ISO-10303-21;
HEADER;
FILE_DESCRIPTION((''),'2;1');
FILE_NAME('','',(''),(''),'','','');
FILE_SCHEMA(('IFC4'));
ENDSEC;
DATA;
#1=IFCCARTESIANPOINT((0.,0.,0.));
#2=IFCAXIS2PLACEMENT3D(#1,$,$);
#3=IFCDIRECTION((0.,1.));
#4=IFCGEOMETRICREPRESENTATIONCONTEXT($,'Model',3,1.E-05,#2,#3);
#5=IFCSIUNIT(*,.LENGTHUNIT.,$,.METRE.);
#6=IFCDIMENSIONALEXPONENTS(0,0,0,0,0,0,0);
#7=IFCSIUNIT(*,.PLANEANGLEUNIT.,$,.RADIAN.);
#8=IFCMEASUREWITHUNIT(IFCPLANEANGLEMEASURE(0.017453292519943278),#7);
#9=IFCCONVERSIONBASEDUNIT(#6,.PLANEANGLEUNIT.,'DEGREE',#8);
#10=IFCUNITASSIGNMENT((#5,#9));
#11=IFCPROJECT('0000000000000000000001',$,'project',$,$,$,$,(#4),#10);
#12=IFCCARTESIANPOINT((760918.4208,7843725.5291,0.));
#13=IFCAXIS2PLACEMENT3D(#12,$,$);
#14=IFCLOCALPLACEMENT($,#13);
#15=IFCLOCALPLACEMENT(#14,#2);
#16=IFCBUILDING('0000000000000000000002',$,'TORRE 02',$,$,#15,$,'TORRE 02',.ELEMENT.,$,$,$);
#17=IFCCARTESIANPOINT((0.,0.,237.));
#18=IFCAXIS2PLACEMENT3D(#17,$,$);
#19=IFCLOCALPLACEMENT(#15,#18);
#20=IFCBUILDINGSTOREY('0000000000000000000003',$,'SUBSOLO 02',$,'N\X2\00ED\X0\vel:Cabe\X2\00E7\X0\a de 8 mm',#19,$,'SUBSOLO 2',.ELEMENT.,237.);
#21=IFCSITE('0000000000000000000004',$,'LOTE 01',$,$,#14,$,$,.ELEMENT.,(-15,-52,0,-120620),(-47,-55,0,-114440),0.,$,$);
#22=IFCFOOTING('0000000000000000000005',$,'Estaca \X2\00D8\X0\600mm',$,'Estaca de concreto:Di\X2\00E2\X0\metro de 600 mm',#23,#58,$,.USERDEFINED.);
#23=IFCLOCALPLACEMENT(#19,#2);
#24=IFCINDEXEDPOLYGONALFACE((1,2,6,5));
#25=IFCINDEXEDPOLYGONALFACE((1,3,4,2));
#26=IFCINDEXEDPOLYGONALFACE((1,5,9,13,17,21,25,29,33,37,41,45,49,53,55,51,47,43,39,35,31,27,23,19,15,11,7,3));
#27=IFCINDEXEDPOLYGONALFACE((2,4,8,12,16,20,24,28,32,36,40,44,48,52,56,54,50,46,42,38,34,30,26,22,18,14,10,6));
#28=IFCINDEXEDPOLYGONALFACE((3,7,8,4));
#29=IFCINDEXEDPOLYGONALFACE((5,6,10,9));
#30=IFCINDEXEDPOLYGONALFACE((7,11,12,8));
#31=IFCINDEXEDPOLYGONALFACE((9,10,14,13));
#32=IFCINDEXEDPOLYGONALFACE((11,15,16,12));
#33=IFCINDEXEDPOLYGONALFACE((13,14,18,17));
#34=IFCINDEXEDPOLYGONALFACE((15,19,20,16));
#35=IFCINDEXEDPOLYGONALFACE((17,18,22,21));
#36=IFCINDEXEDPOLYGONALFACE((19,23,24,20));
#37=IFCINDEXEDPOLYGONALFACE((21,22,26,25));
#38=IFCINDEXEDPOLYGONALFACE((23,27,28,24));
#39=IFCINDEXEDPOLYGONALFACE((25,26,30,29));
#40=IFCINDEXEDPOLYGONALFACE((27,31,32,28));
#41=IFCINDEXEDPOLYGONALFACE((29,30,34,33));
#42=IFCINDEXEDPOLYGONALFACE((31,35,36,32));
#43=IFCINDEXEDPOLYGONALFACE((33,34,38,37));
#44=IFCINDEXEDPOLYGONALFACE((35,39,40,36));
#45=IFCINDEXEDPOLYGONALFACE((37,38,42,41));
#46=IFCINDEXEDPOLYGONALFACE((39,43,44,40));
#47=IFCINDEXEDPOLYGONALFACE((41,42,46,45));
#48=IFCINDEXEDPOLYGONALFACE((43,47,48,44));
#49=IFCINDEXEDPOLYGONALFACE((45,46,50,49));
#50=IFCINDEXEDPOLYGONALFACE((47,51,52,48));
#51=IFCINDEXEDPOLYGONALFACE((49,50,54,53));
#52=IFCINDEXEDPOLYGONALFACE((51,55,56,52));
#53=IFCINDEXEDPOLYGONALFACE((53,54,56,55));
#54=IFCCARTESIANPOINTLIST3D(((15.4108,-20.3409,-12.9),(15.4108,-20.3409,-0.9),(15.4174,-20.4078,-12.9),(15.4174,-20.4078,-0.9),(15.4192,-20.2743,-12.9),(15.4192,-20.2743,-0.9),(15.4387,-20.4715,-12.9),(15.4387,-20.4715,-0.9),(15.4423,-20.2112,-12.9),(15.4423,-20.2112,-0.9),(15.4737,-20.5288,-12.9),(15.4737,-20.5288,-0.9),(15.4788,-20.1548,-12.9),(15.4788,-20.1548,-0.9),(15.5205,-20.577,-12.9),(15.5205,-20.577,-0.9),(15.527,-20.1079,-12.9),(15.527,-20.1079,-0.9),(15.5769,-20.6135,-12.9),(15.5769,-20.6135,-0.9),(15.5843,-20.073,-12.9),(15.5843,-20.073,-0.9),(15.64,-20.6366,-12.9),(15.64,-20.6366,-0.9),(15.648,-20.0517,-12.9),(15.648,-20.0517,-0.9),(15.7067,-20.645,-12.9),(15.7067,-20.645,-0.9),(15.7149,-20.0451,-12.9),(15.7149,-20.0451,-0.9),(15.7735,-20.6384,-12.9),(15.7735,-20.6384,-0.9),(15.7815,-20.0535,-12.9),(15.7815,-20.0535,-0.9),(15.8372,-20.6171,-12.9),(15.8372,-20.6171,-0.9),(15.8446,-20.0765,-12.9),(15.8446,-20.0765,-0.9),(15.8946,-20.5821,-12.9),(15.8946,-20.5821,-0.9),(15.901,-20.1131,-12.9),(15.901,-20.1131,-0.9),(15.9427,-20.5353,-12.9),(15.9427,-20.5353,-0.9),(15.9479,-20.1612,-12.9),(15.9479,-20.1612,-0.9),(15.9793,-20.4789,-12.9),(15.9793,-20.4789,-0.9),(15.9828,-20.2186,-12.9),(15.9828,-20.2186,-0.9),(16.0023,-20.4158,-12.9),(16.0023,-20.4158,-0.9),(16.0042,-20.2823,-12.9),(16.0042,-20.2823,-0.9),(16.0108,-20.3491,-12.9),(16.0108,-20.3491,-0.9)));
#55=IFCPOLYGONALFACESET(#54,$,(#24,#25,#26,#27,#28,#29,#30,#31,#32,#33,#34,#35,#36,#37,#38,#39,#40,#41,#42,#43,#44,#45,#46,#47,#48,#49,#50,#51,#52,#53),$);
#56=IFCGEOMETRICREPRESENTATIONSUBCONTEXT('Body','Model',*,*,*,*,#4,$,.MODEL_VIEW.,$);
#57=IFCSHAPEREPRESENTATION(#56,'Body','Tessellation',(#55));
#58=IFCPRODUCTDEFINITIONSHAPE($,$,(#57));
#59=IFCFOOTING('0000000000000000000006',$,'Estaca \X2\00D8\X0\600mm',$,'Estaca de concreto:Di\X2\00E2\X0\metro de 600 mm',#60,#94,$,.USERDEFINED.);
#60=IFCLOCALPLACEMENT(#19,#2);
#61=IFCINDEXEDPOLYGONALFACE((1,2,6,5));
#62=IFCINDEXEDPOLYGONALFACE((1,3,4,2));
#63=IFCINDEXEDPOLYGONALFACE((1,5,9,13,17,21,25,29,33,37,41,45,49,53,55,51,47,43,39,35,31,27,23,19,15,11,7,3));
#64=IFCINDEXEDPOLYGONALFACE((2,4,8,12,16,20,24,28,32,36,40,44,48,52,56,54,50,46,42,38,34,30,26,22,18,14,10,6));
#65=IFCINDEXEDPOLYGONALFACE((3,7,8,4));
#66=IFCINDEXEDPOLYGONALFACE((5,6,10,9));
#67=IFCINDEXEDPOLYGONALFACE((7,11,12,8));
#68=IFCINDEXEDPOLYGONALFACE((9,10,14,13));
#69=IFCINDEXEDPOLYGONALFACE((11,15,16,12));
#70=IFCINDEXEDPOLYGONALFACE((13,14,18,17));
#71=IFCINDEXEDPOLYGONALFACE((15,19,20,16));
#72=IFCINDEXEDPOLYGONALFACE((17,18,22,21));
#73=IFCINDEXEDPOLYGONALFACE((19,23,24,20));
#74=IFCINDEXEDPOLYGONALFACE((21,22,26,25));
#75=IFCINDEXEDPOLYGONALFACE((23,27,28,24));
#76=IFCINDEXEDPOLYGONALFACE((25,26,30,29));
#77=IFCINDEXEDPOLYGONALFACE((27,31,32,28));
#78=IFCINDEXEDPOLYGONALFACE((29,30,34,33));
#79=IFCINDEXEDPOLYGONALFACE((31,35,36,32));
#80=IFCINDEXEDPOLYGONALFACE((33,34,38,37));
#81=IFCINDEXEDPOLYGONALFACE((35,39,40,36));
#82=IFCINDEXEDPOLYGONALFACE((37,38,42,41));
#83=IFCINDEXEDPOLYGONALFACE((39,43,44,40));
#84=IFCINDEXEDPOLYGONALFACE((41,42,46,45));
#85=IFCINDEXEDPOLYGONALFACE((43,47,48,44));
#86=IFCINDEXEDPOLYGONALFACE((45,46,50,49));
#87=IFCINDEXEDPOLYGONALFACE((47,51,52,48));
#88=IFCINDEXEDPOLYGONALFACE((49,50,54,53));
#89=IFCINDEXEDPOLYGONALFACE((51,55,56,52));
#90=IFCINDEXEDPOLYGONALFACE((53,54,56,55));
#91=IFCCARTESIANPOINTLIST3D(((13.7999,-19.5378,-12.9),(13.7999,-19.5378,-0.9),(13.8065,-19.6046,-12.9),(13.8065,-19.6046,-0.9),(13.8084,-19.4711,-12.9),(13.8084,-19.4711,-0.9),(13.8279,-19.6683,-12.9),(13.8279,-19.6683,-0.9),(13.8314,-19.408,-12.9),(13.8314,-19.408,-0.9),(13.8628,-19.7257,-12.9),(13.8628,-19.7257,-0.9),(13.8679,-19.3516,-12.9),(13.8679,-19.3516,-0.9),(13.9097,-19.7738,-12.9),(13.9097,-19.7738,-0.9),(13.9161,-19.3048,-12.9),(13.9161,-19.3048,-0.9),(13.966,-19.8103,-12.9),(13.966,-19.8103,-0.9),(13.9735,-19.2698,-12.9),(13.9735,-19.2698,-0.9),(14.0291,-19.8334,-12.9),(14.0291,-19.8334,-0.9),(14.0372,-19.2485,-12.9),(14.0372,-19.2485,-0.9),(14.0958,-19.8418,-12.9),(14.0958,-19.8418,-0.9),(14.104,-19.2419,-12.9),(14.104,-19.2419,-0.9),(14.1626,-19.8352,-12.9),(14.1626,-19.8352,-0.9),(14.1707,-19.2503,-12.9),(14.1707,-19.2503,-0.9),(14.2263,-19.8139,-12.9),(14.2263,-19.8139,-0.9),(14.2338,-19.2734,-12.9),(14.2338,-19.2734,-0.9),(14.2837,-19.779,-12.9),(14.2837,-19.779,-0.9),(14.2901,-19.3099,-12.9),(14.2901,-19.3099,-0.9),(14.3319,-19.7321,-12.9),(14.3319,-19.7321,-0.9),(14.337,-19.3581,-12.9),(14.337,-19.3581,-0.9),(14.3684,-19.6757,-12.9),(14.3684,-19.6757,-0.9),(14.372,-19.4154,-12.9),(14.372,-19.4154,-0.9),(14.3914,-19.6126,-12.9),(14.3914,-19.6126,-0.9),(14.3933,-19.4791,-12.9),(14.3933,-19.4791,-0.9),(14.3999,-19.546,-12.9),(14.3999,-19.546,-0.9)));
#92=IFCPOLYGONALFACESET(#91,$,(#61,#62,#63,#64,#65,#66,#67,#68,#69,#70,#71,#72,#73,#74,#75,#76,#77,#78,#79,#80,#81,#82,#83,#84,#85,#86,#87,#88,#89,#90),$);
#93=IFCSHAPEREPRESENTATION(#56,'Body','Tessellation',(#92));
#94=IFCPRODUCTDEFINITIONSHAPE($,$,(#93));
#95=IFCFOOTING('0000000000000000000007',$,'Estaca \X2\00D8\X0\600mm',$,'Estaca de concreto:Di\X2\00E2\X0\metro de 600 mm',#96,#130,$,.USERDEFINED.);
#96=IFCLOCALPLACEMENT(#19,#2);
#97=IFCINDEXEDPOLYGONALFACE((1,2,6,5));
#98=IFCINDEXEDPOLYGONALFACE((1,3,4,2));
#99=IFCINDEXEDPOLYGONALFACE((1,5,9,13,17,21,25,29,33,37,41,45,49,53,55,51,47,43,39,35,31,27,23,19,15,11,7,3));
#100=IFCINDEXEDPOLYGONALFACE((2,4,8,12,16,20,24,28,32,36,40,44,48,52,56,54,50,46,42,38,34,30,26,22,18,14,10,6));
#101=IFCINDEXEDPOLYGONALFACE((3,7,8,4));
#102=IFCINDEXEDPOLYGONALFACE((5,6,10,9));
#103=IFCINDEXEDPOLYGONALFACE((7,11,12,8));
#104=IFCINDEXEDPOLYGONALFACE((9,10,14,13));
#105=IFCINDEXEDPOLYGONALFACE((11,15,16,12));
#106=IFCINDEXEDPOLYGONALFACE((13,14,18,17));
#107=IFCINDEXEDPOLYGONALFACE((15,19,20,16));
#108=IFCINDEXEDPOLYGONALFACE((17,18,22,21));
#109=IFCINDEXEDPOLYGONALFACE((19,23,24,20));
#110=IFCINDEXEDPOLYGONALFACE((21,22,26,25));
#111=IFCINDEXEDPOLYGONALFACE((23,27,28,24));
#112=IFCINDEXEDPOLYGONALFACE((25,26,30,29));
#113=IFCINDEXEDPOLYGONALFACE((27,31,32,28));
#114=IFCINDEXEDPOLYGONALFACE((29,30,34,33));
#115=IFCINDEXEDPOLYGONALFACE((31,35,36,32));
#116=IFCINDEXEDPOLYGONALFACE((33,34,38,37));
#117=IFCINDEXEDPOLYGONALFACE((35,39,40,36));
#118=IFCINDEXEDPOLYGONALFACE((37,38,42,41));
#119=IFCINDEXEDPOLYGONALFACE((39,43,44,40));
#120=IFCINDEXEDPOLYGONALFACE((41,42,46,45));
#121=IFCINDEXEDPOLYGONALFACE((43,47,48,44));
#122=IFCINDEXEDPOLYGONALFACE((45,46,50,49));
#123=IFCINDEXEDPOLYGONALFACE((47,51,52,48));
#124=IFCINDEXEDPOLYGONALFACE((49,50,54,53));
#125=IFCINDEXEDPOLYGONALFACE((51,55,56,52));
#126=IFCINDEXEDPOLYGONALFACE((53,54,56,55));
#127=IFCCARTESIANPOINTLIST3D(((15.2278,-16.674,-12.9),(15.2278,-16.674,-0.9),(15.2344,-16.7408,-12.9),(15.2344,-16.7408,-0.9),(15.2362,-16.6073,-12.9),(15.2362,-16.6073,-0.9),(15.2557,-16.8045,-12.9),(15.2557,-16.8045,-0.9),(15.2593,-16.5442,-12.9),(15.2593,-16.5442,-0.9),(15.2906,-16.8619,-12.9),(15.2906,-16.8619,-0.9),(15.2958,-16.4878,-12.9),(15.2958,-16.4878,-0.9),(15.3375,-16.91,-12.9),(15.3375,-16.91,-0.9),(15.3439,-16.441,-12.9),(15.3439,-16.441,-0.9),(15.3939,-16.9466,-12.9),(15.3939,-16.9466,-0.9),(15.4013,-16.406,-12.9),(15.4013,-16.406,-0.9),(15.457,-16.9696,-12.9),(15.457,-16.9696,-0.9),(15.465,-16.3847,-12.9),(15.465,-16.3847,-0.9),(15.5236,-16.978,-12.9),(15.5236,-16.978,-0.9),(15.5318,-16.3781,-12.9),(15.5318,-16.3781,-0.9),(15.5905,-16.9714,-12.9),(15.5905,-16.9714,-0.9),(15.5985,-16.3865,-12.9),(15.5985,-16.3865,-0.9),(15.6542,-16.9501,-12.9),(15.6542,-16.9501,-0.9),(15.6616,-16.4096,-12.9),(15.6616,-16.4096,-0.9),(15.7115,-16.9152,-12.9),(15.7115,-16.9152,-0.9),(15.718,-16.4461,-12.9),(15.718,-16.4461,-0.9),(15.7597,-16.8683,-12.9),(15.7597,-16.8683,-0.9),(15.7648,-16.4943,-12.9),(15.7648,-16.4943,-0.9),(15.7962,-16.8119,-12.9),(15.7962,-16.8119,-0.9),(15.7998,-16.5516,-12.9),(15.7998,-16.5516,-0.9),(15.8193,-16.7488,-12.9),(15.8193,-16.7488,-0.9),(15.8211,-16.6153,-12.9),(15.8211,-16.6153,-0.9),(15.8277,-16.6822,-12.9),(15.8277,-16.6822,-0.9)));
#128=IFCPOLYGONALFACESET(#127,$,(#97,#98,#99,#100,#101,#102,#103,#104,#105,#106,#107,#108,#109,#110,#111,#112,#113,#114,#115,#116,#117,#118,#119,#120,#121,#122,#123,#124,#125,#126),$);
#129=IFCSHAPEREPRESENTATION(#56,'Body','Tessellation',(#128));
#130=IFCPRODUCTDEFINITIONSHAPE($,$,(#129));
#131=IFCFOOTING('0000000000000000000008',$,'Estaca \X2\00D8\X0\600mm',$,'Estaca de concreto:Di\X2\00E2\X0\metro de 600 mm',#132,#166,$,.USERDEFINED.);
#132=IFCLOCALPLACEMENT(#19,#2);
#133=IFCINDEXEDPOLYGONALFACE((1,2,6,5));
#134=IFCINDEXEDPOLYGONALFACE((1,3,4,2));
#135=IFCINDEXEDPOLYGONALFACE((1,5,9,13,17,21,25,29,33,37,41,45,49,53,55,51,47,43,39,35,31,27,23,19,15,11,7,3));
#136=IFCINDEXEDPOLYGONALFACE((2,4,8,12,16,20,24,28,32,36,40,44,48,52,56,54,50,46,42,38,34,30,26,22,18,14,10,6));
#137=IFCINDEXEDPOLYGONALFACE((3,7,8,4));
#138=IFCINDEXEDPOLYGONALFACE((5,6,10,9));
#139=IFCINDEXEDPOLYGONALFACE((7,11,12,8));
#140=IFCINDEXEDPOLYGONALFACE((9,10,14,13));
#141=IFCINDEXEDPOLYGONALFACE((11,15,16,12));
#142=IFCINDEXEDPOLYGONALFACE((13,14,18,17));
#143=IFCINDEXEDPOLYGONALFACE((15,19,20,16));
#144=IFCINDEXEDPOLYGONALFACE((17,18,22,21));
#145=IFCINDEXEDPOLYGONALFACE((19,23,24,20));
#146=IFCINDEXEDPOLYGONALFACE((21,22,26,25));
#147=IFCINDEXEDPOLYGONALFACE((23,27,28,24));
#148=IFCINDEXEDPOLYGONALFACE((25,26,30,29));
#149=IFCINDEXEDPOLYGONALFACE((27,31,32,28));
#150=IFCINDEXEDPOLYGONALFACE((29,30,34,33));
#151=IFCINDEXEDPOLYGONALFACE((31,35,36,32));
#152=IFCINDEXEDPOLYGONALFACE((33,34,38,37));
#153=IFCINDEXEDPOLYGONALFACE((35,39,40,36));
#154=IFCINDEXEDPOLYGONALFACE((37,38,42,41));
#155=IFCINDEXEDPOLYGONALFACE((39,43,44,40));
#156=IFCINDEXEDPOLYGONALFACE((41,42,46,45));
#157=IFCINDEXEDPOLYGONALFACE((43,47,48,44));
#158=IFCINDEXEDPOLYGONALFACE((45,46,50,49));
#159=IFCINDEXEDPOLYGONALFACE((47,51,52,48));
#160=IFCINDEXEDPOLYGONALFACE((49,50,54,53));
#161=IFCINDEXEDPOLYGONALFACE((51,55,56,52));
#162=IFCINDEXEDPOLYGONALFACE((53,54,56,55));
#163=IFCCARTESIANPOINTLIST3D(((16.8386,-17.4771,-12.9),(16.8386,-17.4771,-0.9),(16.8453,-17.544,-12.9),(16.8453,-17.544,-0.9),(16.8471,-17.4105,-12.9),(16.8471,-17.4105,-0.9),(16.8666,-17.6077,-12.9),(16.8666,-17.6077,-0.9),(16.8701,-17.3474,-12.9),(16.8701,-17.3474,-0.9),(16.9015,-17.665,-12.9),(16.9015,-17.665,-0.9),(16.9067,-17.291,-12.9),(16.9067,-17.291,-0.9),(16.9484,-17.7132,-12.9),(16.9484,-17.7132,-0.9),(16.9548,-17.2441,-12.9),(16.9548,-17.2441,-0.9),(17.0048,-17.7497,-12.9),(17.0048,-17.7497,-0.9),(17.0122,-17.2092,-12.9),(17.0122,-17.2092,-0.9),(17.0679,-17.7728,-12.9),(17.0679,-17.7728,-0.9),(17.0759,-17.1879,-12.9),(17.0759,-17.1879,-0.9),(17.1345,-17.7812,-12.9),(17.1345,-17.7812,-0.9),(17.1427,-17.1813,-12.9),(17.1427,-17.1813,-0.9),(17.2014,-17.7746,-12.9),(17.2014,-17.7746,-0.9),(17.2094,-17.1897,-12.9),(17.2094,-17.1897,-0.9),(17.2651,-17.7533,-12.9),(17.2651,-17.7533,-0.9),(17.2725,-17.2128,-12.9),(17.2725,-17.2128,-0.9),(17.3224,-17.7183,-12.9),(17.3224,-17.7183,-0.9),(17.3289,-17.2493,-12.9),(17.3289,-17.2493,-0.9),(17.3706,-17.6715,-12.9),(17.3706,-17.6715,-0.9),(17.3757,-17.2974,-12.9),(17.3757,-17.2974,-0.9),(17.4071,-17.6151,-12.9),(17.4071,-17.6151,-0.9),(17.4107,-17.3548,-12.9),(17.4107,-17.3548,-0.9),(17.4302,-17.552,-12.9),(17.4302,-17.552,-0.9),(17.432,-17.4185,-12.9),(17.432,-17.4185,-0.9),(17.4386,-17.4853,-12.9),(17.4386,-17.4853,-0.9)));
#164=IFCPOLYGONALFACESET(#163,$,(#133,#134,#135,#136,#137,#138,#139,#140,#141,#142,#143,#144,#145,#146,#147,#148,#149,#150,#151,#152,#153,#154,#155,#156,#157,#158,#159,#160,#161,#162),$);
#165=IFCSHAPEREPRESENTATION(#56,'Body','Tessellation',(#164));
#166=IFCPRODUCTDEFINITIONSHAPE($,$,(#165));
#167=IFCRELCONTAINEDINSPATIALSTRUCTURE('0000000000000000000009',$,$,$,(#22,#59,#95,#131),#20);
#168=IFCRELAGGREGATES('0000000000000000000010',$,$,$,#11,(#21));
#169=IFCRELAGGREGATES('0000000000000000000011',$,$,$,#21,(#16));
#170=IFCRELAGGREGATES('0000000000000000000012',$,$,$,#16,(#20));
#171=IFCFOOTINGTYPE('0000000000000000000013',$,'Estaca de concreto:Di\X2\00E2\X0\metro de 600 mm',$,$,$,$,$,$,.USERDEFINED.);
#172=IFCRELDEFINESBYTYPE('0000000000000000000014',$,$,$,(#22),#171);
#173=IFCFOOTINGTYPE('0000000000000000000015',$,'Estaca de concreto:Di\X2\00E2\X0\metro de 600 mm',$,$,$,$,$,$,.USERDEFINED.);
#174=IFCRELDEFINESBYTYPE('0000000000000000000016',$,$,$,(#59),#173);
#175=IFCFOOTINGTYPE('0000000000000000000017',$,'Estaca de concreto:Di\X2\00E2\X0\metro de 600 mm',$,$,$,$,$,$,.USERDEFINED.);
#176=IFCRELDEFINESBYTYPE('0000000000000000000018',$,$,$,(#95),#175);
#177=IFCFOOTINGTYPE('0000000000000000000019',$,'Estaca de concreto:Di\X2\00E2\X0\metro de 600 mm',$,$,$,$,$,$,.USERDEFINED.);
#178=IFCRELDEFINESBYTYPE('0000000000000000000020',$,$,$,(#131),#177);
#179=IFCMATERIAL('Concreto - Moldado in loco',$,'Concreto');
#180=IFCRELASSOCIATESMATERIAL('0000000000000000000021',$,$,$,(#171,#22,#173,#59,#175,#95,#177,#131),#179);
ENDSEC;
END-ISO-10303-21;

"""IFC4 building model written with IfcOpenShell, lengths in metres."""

from ifc_helpers import new_model, entity, si_unit, converted_unit, direction, frame, origin, place, context, subcontext, project, spatial, arc, indexed_curve, outline, extrude, source, transform, mapped, material, type_object, type_shapes, element, save


model = new_model("IFC4")

# Units and contexts
model_context = context("Model", 3, precision=1e-05, world=origin(), true_north=direction((0.0, 1.0)))
body_context = subcontext(model_context, "Body", "Model", "MODEL_VIEW")
ifc_project = project(units=[si_unit("LENGTHUNIT", "METRE"), converted_unit("PLANEANGLEUNIT", "DEGREE", entity("IfcPlaneAngleMeasure", 0.017453292519943278), si_unit("PLANEANGLEUNIT", "RADIAN"), dimensions=[0, 0, 0, 0, 0, 0, 0])], contexts=[model_context])

# Site, building, storey
site_placement = place(None, frame((760918.4208, 7843725.5291, 0.0)))
site = spatial("IfcSite", under=ifc_project, at=site_placement, Name="LOTE 01", CompositionType="ELEMENT", RefLatitude=(-15, -52, 0, -120620), RefLongitude=(-47, -55, 0, -114440), RefElevation=0.0)
building_placement = place(site_placement, origin())
building = spatial("IfcBuilding", under=site, at=building_placement, Name="TORRE 02", LongName="TORRE 02", CompositionType="ELEMENT")
storey_placement = place(building_placement, frame((0.0, 0.0, 237.0)))
storey = spatial("IfcBuildingStorey", under=building, at=storey_placement, Name="SUBSOLO 02", ObjectType="Nível:Cabeça de 8 mm", LongName="SUBSOLO 2", CompositionType="ELEMENT", Elevation=237.0)

# Footings
ifc_material = material(Name="Concreto - Moldado in loco", Category="Concreto")
placement = place(building_placement, frame((0.0, 0.0, 237.0)))
footing_type_1 = type_object("IfcFootingType", Name="Estaca de concreto:Diâmetro de 600 mm", PredefinedType="USERDEFINED", material=ifc_material)
shared_shape_1 = source(origin(), body_context, "Body", "SweptSolid", [
    extrude(outline(indexed_curve([(-0.3, 0.0), (0.0, -0.3), (0.3, 0.0), (0.0, 0.3)], segments=[arc(1, 2, 3), arc(3, 4, 1)], self_intersect=False)), frame((15.7108, -20.345, -12.0), z_axis=(0.0, 0.0, 1.0), x_axis=(0.894934, -0.446198, 0.0)), (0.0, 0.0, 1.0), 12.0),
])
type_shapes(footing_type_1, [shared_shape_1])
footing_1_placement = place(placement, frame((0.0, 0.0, -0.9)))
element("IfcFooting", 1, at=footing_1_placement, inside=storey, type_object=footing_type_1, material=ifc_material, Name="Estaca Ø600mm", ObjectType="Estaca de concreto:Diâmetro de 600 mm", PredefinedType="USERDEFINED", context=body_context, shape_type="MappedRepresentation", body=[
    mapped(shared_shape_1, transform((0.0, 0.0, 0.0), scale=1.0)),
])
footing_type_2 = type_object("IfcFootingType", Name="Estaca de concreto:Diâmetro de 600 mm", PredefinedType="USERDEFINED", material=ifc_material)
shared_shape_2 = source(origin(), body_context, "Body", "SweptSolid", [
    extrude(outline(indexed_curve([(-0.3, 0.0), (0.0, -0.3), (0.3, 0.0), (0.0, 0.3)], segments=[arc(1, 2, 3), arc(3, 4, 1)], self_intersect=False)), frame((14.0999, -19.5419, -12.0), z_axis=(0.0, 0.0, 1.0), x_axis=(0.894934, -0.446198, 0.0)), (0.0, 0.0, 1.0), 12.0),
])
type_shapes(footing_type_2, [shared_shape_2])
footing_2_placement = place(placement, frame((0.0, 0.0, -0.9)))
element("IfcFooting", 2, at=footing_2_placement, inside=storey, type_object=footing_type_2, material=ifc_material, Name="Estaca Ø600mm", ObjectType="Estaca de concreto:Diâmetro de 600 mm", PredefinedType="USERDEFINED", context=body_context, shape_type="MappedRepresentation", body=[
    mapped(shared_shape_2, transform((0.0, 0.0, 0.0), scale=1.0)),
])
footing_type_3 = type_object("IfcFootingType", Name="Estaca de concreto:Diâmetro de 600 mm", PredefinedType="USERDEFINED", material=ifc_material)
shared_shape_3 = source(origin(), body_context, "Body", "SweptSolid", [
    extrude(outline(indexed_curve([(-0.3, 0.0), (0.0, -0.3), (0.3, 0.0), (0.0, 0.3)], segments=[arc(1, 2, 3), arc(3, 4, 1)], self_intersect=False)), frame((15.5277, -16.6781, -12.0), z_axis=(0.0, 0.0, 1.0), x_axis=(0.894934, -0.446198, 0.0)), (0.0, 0.0, 1.0), 12.0),
])
type_shapes(footing_type_3, [shared_shape_3])
footing_3_placement = place(placement, frame((0.0, 0.0, -0.9)))
element("IfcFooting", 3, at=footing_3_placement, inside=storey, type_object=footing_type_3, material=ifc_material, Name="Estaca Ø600mm", ObjectType="Estaca de concreto:Diâmetro de 600 mm", PredefinedType="USERDEFINED", context=body_context, shape_type="MappedRepresentation", body=[
    mapped(shared_shape_3, transform((0.0, 0.0, 0.0), scale=1.0)),
])
footing_type_4 = type_object("IfcFootingType", Name="Estaca de concreto:Diâmetro de 600 mm", PredefinedType="USERDEFINED", material=ifc_material)
shared_shape_4 = source(origin(), body_context, "Body", "SweptSolid", [
    extrude(outline(indexed_curve([(-0.3, 0.0), (0.0, -0.3), (0.3, 0.0), (0.0, 0.3)], segments=[arc(1, 2, 3), arc(3, 4, 1)], self_intersect=False)), frame((17.1386, -17.4812, -12.0), z_axis=(0.0, 0.0, 1.0), x_axis=(0.894934, -0.446198, 0.0)), (0.0, 0.0, 1.0), 12.0),
])
type_shapes(footing_type_4, [shared_shape_4])
footing_4_placement = place(placement, frame((0.0, 0.0, -0.9)))
element("IfcFooting", 4, at=footing_4_placement, inside=storey, type_object=footing_type_4, material=ifc_material, Name="Estaca Ø600mm", ObjectType="Estaca de concreto:Diâmetro de 600 mm", PredefinedType="USERDEFINED", context=body_context, shape_type="MappedRepresentation", body=[
    mapped(shared_shape_4, transform((0.0, 0.0, 0.0), scale=1.0)),
])

save(model, "model.ifc")
